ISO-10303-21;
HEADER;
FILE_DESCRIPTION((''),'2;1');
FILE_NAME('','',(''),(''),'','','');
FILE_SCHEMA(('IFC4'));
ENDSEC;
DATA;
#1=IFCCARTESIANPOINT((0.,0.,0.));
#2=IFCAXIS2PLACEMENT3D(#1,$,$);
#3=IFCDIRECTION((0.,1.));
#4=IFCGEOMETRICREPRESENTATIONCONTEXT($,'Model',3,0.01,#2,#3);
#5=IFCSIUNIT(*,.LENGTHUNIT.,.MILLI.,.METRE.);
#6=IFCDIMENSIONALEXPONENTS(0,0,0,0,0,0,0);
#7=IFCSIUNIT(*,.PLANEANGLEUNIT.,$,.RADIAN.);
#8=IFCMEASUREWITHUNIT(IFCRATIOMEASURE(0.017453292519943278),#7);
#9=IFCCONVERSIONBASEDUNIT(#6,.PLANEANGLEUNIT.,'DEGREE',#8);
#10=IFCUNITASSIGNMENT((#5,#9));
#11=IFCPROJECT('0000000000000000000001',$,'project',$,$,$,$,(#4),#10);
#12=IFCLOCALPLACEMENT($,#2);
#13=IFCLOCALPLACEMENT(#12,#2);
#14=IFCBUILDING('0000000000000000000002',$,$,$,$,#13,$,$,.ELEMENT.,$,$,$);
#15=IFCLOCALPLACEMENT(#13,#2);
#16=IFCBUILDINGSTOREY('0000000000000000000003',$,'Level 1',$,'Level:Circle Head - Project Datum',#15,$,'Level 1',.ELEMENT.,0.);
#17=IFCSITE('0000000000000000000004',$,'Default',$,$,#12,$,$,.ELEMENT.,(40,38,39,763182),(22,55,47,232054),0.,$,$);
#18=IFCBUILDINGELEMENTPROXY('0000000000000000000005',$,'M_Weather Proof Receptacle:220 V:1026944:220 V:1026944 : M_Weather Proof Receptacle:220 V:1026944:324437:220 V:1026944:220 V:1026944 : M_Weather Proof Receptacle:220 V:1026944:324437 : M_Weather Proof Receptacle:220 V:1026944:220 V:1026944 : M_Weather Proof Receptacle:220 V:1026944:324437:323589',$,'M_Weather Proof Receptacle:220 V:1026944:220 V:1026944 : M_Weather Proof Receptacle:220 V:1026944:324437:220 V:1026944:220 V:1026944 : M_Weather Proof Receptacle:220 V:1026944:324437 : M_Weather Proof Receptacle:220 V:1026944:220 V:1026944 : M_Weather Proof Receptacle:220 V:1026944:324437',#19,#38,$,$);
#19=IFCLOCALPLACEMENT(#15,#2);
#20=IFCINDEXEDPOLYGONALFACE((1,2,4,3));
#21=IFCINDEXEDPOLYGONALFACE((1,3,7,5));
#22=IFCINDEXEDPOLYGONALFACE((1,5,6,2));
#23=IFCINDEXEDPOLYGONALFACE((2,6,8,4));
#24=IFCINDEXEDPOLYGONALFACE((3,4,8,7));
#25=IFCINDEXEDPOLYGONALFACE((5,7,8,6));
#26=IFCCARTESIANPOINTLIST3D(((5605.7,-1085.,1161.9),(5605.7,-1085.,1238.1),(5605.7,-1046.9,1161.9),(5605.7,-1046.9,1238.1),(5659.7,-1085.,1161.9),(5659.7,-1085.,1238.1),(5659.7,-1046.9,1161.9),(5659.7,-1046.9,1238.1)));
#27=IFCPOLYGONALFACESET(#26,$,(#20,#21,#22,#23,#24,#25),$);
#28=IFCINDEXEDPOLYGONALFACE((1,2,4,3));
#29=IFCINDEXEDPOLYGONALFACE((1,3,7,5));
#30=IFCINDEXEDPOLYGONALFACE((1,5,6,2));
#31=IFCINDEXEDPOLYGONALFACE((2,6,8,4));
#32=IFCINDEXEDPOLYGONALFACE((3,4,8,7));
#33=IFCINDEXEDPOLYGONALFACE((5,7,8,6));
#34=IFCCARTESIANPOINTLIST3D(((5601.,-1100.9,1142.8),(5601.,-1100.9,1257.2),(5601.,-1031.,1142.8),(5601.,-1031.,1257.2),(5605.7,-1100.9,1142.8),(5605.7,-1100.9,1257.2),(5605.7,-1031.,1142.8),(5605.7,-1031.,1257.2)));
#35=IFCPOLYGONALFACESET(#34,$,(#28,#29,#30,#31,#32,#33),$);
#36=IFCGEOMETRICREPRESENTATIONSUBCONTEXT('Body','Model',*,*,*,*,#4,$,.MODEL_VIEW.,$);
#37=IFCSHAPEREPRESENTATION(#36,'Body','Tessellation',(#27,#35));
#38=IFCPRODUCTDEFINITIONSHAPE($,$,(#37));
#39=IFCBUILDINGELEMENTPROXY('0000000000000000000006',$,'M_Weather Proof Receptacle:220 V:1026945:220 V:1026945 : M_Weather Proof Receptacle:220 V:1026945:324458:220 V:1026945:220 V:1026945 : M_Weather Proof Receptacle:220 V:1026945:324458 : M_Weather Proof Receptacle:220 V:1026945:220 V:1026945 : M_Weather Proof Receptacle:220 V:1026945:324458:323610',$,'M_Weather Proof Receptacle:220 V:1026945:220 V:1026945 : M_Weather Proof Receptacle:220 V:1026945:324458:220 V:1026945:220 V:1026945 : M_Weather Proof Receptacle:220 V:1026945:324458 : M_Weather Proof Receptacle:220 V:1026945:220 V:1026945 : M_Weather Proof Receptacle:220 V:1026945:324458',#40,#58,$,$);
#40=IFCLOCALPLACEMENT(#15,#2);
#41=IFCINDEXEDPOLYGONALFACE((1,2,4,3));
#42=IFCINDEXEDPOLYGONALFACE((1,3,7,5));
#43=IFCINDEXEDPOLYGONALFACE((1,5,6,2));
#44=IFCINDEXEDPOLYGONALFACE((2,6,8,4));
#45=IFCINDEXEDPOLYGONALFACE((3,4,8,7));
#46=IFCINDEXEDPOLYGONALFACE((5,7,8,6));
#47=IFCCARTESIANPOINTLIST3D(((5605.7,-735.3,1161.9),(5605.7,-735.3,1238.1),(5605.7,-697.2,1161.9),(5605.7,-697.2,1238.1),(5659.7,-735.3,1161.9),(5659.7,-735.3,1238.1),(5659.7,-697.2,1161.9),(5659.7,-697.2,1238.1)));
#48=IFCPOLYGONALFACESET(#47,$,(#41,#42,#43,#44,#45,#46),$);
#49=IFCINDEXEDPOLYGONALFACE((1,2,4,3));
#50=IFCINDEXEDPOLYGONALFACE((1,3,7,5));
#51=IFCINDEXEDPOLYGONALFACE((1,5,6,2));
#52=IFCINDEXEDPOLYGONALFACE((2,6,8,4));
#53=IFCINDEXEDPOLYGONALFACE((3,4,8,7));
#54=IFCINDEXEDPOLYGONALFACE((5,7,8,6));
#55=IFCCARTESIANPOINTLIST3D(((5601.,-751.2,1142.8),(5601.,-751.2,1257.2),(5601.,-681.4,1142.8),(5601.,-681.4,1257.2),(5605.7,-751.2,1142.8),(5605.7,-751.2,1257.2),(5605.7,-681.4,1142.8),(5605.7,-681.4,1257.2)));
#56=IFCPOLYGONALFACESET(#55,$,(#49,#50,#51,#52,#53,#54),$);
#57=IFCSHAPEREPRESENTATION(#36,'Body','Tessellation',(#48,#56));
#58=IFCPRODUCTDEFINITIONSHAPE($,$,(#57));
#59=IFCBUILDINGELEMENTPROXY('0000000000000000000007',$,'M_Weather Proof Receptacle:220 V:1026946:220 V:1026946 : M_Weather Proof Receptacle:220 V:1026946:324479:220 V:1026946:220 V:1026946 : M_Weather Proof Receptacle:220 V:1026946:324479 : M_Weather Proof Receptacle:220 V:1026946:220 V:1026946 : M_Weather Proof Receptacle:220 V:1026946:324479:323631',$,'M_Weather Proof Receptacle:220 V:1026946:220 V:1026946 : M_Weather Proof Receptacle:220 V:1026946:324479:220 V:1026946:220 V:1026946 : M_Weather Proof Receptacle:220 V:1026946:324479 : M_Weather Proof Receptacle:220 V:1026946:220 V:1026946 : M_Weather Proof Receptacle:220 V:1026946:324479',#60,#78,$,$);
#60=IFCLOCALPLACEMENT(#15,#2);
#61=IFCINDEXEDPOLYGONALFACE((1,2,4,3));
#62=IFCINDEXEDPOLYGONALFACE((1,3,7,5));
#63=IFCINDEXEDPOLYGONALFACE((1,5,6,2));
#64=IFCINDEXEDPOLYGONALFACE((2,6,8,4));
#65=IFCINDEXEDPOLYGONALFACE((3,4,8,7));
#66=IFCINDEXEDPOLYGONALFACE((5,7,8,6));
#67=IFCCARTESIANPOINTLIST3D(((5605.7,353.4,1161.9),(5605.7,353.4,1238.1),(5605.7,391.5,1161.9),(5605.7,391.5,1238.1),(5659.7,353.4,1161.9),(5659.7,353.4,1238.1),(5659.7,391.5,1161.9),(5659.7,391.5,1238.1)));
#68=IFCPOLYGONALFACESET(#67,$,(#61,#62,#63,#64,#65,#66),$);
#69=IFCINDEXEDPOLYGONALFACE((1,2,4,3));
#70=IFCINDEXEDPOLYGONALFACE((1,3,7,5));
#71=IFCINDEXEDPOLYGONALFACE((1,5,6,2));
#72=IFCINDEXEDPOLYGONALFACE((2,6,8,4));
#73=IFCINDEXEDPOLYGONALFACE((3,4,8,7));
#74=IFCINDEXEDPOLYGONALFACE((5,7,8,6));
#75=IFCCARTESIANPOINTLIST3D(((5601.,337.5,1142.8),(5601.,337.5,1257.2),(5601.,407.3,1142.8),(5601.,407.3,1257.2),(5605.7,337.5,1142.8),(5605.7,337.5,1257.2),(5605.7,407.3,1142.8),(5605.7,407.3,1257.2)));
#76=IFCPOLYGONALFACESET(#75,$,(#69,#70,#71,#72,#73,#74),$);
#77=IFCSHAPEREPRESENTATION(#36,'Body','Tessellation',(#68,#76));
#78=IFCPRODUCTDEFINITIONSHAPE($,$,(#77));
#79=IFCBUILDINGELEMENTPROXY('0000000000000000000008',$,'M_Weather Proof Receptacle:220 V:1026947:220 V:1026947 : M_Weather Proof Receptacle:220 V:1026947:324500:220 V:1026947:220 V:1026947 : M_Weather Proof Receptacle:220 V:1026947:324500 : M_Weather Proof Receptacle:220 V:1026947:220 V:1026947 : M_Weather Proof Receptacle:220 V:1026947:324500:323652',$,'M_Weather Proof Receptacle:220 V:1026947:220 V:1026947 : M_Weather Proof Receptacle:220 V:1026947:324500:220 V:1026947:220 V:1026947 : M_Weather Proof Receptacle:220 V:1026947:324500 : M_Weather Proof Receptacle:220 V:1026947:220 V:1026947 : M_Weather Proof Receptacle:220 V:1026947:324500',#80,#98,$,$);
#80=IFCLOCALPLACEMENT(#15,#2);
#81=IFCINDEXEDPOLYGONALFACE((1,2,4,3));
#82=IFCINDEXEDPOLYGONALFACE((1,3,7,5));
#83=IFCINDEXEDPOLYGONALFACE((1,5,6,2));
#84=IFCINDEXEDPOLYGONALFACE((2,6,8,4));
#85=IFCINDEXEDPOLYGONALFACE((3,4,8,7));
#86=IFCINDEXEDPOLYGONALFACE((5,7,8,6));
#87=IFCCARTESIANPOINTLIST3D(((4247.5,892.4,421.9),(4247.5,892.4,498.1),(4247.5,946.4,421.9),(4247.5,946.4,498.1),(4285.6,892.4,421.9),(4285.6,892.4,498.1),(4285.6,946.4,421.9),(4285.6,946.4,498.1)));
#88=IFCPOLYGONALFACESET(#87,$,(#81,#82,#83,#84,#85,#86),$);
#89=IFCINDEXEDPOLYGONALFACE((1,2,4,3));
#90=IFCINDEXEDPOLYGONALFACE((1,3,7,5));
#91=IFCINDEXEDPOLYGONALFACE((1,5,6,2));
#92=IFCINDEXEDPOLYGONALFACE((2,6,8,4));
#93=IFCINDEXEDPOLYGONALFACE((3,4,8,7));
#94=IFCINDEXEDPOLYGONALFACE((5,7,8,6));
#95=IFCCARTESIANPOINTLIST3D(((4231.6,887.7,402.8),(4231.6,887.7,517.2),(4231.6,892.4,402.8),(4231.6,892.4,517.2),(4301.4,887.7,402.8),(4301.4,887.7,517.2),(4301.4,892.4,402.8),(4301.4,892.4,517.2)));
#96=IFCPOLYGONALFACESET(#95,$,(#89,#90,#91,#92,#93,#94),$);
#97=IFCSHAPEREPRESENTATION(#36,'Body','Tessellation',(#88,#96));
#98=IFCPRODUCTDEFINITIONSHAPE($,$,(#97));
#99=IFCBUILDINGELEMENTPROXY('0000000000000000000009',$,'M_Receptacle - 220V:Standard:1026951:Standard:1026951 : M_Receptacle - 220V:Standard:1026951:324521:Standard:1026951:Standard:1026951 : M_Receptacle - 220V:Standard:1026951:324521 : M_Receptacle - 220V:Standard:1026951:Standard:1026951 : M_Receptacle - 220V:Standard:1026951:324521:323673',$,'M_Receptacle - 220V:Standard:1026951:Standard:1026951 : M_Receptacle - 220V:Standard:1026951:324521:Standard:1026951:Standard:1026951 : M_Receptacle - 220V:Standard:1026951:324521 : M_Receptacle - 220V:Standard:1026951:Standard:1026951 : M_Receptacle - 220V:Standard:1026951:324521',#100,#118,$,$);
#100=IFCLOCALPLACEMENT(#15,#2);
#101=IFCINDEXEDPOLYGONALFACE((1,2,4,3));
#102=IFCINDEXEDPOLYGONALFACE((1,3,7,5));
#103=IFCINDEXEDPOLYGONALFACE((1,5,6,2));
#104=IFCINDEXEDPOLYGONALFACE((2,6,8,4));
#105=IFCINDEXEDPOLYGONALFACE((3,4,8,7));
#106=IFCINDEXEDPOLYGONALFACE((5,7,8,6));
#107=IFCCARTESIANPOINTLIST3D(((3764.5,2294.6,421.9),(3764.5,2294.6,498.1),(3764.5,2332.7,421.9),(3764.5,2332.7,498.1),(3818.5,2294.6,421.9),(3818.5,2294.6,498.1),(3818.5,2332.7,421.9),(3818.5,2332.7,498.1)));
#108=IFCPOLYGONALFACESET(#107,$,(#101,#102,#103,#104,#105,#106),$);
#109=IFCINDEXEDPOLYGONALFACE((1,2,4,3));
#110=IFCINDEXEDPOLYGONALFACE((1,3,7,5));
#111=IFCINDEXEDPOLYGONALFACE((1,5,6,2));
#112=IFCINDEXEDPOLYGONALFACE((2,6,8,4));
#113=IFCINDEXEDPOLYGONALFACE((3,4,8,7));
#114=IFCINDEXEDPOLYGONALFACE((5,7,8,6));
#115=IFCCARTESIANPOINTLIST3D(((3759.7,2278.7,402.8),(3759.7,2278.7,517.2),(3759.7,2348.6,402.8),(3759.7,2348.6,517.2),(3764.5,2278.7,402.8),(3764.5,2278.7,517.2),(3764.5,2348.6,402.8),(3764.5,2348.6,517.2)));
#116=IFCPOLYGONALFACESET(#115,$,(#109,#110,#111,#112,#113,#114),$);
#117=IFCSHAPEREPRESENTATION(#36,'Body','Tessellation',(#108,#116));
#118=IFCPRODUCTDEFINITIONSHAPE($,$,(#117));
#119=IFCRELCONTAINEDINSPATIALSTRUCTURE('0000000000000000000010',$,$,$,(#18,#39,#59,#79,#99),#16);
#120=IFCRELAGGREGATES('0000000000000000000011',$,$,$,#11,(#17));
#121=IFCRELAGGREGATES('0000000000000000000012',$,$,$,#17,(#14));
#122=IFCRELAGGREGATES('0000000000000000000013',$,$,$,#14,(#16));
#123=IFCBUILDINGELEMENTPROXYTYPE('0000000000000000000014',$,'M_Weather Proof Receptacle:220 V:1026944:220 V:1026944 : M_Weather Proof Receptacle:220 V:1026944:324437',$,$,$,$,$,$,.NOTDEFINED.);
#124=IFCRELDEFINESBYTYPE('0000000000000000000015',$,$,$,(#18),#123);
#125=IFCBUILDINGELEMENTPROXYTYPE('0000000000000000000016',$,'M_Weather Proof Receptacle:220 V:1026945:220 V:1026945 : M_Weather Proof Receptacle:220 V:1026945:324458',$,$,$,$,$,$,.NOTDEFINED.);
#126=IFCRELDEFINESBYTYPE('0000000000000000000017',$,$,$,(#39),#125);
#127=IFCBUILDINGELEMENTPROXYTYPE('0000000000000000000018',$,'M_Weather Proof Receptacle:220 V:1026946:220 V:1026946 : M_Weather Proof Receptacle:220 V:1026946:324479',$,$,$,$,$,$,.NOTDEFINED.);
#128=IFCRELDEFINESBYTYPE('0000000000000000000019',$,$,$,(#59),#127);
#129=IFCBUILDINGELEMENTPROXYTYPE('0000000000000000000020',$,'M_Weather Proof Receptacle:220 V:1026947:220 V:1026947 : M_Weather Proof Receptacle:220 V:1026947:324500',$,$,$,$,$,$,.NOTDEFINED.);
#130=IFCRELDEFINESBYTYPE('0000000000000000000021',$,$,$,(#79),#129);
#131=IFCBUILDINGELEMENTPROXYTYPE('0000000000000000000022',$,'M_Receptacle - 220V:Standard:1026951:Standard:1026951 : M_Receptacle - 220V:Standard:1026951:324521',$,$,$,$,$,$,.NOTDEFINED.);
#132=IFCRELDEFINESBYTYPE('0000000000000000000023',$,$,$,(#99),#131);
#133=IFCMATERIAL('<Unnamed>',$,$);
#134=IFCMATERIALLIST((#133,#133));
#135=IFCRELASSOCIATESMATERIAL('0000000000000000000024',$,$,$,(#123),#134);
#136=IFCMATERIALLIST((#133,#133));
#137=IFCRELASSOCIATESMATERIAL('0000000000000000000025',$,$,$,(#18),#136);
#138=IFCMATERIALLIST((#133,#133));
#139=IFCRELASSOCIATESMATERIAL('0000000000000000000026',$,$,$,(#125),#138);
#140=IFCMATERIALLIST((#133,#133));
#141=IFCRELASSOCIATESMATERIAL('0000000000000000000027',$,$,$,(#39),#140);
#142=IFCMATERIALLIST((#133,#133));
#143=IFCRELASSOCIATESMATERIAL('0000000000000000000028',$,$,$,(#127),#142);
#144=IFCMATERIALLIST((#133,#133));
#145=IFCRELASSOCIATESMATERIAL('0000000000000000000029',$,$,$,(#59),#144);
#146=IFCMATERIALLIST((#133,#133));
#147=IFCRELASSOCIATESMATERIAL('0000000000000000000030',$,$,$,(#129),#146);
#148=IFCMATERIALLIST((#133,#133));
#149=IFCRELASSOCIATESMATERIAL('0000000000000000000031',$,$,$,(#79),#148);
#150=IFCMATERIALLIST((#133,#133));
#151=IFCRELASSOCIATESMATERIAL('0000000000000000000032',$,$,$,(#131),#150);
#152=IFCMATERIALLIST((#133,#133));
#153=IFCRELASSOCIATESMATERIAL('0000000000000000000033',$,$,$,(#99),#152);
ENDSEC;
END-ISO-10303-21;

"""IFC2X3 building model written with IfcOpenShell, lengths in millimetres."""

from ifc_helpers import new_model, entity, si_unit, converted_unit, direction, frame, frame_2d, origin, origin_2d_with_axis, place, context, subcontext, project, spatial, rectangle, extrude, source, transform, mapped, material, material_list, type_object, type_shapes, element, save


model = new_model("IFC2X3")

# Units and contexts
model_context = context("Model", 3, precision=0.01, world=origin(), true_north=direction((0.0, 1.0)))
body_context = subcontext(model_context, "Body", "Model", "MODEL_VIEW")
ifc_project = project(units=[si_unit("LENGTHUNIT", "METRE", prefix="MILLI"), converted_unit("PLANEANGLEUNIT", "DEGREE", entity("IfcRatioMeasure", 0.017453292519943278), si_unit("PLANEANGLEUNIT", "RADIAN"), dimensions=[0, 0, 0, 0, 0, 0, 0])], contexts=[model_context])

# Site, building, storey
site_placement = place(None, origin())
site = spatial("IfcSite", under=ifc_project, at=site_placement, Name="Default", CompositionType="ELEMENT", RefLatitude=(40, 38, 39, 763182), RefLongitude=(22, 55, 47, 232054), RefElevation=0.0)
building_placement = place(site_placement, origin())
building = spatial("IfcBuilding", under=site, at=building_placement, CompositionType="ELEMENT")
storey_placement = place(building_placement, origin())
storey = spatial("IfcBuildingStorey", under=building, at=storey_placement, Name="Level 1", ObjectType="Level:Circle Head - Project Datum", LongName="Level 1", CompositionType="ELEMENT", Elevation=0.0)

# Shared definitions
ifc_material_1 = material(Name="<Unnamed>")

# Building element proxies
ifc_material_list_1 = material_list([ifc_material_1, ifc_material_1])
ifc_material_list_2 = material_list([ifc_material_1, ifc_material_1])
building_element_proxy_type_1 = type_object("IfcBuildingElementProxyType", Name="M_Weather Proof Receptacle:220 V:1026944:220 V:1026944 : M_Weather Proof Receptacle:220 V:1026944:324437", PredefinedType="NOTDEFINED", material=ifc_material_list_2)
shared_shape_1 = source(origin(), body_context, "Body", "SweptSolid", [
    extrude(rectangle(XDim=38.1, YDim=54.0, at=origin_2d_with_axis()), frame((5632.7, -1065.9, 1161.9), z_axis=(0.0, 0.0, 1.0), x_axis=(0.0, 1.0, 0.0)), (0.0, 0.0, 1.0), 76.2),
    extrude(rectangle(XDim=69.8, YDim=4.8, at=frame_2d((0.0, 0.0), x_axis=(1.0, 0.0))), frame((5603.3, -1065.9, 1142.8), z_axis=(0.0, 0.0, 1.0), x_axis=(0.0, 1.0, 0.0)), (0.0, 0.0, 1.0), 114.3),
])
type_shapes(building_element_proxy_type_1, [shared_shape_1])
proxy_1_placement = place(storey_placement, origin())
element("IfcBuildingElementProxy", 1, at=proxy_1_placement, inside=storey, type_object=building_element_proxy_type_1, material=ifc_material_list_1, Name="M_Weather Proof Receptacle:220 V:1026944:220 V:1026944 : M_Weather Proof Receptacle:220 V:1026944:324437:220 V:1026944:220 V:1026944 : M_Weather Proof Receptacle:220 V:1026944:324437 : M_Weather Proof Receptacle:220 V:1026944:220 V:1026944 : M_Weather Proof Receptacle:220 V:1026944:324437:323589", ObjectType="M_Weather Proof Receptacle:220 V:1026944:220 V:1026944 : M_Weather Proof Receptacle:220 V:1026944:324437:220 V:1026944:220 V:1026944 : M_Weather Proof Receptacle:220 V:1026944:324437 : M_Weather Proof Receptacle:220 V:1026944:220 V:1026944 : M_Weather Proof Receptacle:220 V:1026944:324437", context=body_context, shape_type="MappedRepresentation", body=[
    mapped(shared_shape_1, transform((0.0, 0.0, 0.0), scale=1.0)),
])
ifc_material_list_3 = material_list([ifc_material_1, ifc_material_1])
ifc_material_list_4 = material_list([ifc_material_1, ifc_material_1])
building_element_proxy_type_2 = type_object("IfcBuildingElementProxyType", Name="M_Weather Proof Receptacle:220 V:1026945:220 V:1026945 : M_Weather Proof Receptacle:220 V:1026945:324458", PredefinedType="NOTDEFINED", material=ifc_material_list_4)
shared_shape_2 = source(origin(), body_context, "Body", "SweptSolid", [
    extrude(rectangle(XDim=38.1, YDim=54.0, at=origin_2d_with_axis()), frame((5632.7, -716.3, 1161.9), z_axis=(0.0, 0.0, 1.0), x_axis=(0.0, 1.0, 0.0)), (0.0, 0.0, 1.0), 76.2),
    extrude(rectangle(XDim=69.8, YDim=4.8, at=frame_2d((0.0, 0.0), x_axis=(1.0, 0.0))), frame((5603.3, -716.3, 1142.8), z_axis=(0.0, 0.0, 1.0), x_axis=(0.0, 1.0, 0.0)), (0.0, 0.0, 1.0), 114.3),
])
type_shapes(building_element_proxy_type_2, [shared_shape_2])
proxy_2_placement = place(storey_placement, origin())
element("IfcBuildingElementProxy", 2, at=proxy_2_placement, inside=storey, type_object=building_element_proxy_type_2, material=ifc_material_list_3, Name="M_Weather Proof Receptacle:220 V:1026945:220 V:1026945 : M_Weather Proof Receptacle:220 V:1026945:324458:220 V:1026945:220 V:1026945 : M_Weather Proof Receptacle:220 V:1026945:324458 : M_Weather Proof Receptacle:220 V:1026945:220 V:1026945 : M_Weather Proof Receptacle:220 V:1026945:324458:323610", ObjectType="M_Weather Proof Receptacle:220 V:1026945:220 V:1026945 : M_Weather Proof Receptacle:220 V:1026945:324458:220 V:1026945:220 V:1026945 : M_Weather Proof Receptacle:220 V:1026945:324458 : M_Weather Proof Receptacle:220 V:1026945:220 V:1026945 : M_Weather Proof Receptacle:220 V:1026945:324458", context=body_context, shape_type="MappedRepresentation", body=[
    mapped(shared_shape_2, transform((0.0, 0.0, 0.0), scale=1.0)),
])
ifc_material_list_5 = material_list([ifc_material_1, ifc_material_1])
ifc_material_list_6 = material_list([ifc_material_1, ifc_material_1])
building_element_proxy_type_3 = type_object("IfcBuildingElementProxyType", Name="M_Weather Proof Receptacle:220 V:1026946:220 V:1026946 : M_Weather Proof Receptacle:220 V:1026946:324479", PredefinedType="NOTDEFINED", material=ifc_material_list_6)
shared_shape_3 = source(origin(), body_context, "Body", "SweptSolid", [
    extrude(rectangle(XDim=38.1, YDim=54.0, at=frame_2d((0.0, 0.0), x_axis=(1.0, 0.0))), frame((5632.7, 372.4, 1161.9), z_axis=(0.0, 0.0, 1.0), x_axis=(0.0, 1.0, 0.0)), (0.0, 0.0, 1.0), 76.2),
    extrude(rectangle(XDim=69.8, YDim=4.8, at=frame_2d((0.0, 0.0), x_axis=(1.0, 0.0))), frame((5603.3, 372.4, 1142.8), z_axis=(0.0, 0.0, 1.0), x_axis=(0.0, 1.0, 0.0)), (0.0, 0.0, 1.0), 114.3),
])
type_shapes(building_element_proxy_type_3, [shared_shape_3])
proxy_3_placement = place(storey_placement, origin())
element("IfcBuildingElementProxy", 3, at=proxy_3_placement, inside=storey, type_object=building_element_proxy_type_3, material=ifc_material_list_5, Name="M_Weather Proof Receptacle:220 V:1026946:220 V:1026946 : M_Weather Proof Receptacle:220 V:1026946:324479:220 V:1026946:220 V:1026946 : M_Weather Proof Receptacle:220 V:1026946:324479 : M_Weather Proof Receptacle:220 V:1026946:220 V:1026946 : M_Weather Proof Receptacle:220 V:1026946:324479:323631", ObjectType="M_Weather Proof Receptacle:220 V:1026946:220 V:1026946 : M_Weather Proof Receptacle:220 V:1026946:324479:220 V:1026946:220 V:1026946 : M_Weather Proof Receptacle:220 V:1026946:324479 : M_Weather Proof Receptacle:220 V:1026946:220 V:1026946 : M_Weather Proof Receptacle:220 V:1026946:324479", context=body_context, shape_type="MappedRepresentation", body=[
    mapped(shared_shape_3, transform((0.0, 0.0, 0.0), scale=1.0)),
])
ifc_material_list_7 = material_list([ifc_material_1, ifc_material_1])
ifc_material_list_8 = material_list([ifc_material_1, ifc_material_1])
building_element_proxy_type_4 = type_object("IfcBuildingElementProxyType", Name="M_Weather Proof Receptacle:220 V:1026947:220 V:1026947 : M_Weather Proof Receptacle:220 V:1026947:324500", PredefinedType="NOTDEFINED", material=ifc_material_list_8)
shared_shape_4 = source(origin(), body_context, "Body", "SweptSolid", [
    extrude(rectangle(XDim=38.1, YDim=54.0, at=frame_2d((0.0, 0.0), x_axis=(1.0, 0.0))), frame((4266.5, 919.4, 421.9), z_axis=(0.0, 0.0, 1.0), x_axis=(-1.0, 0.0, 0.0)), (0.0, 0.0, 1.0), 76.2),
    extrude(rectangle(XDim=69.8, YDim=4.8, at=frame_2d((0.0, 0.0), x_axis=(1.0, 0.0))), frame((4266.5, 890.0, 402.8), z_axis=(0.0, 0.0, 1.0), x_axis=(-1.0, 0.0, 0.0)), (0.0, 0.0, 1.0), 114.3),
])
type_shapes(building_element_proxy_type_4, [shared_shape_4])
proxy_4_placement = place(storey_placement, origin())
element("IfcBuildingElementProxy", 4, at=proxy_4_placement, inside=storey, type_object=building_element_proxy_type_4, material=ifc_material_list_7, Name="M_Weather Proof Receptacle:220 V:1026947:220 V:1026947 : M_Weather Proof Receptacle:220 V:1026947:324500:220 V:1026947:220 V:1026947 : M_Weather Proof Receptacle:220 V:1026947:324500 : M_Weather Proof Receptacle:220 V:1026947:220 V:1026947 : M_Weather Proof Receptacle:220 V:1026947:324500:323652", ObjectType="M_Weather Proof Receptacle:220 V:1026947:220 V:1026947 : M_Weather Proof Receptacle:220 V:1026947:324500:220 V:1026947:220 V:1026947 : M_Weather Proof Receptacle:220 V:1026947:324500 : M_Weather Proof Receptacle:220 V:1026947:220 V:1026947 : M_Weather Proof Receptacle:220 V:1026947:324500", context=body_context, shape_type="MappedRepresentation", body=[
    mapped(shared_shape_4, transform((0.0, 0.0, 0.0), scale=1.0)),
])
ifc_material_list_9 = material_list([ifc_material_1, ifc_material_1])
ifc_material_list_10 = material_list([ifc_material_1, ifc_material_1])
building_element_proxy_type_5 = type_object("IfcBuildingElementProxyType", Name="M_Receptacle - 220V:Standard:1026951:Standard:1026951 : M_Receptacle - 220V:Standard:1026951:324521", PredefinedType="NOTDEFINED", material=ifc_material_list_10)
shared_shape_5 = source(origin(), body_context, "Body", "SweptSolid", [
    extrude(rectangle(XDim=38.1, YDim=54.0, at=origin_2d_with_axis()), frame((3791.5, 2313.7, 421.9), z_axis=(0.0, 0.0, 1.0), x_axis=(0.0, 1.0, 0.0)), (0.0, 0.0, 1.0), 76.2),
    extrude(rectangle(XDim=69.8, YDim=4.8, at=origin_2d_with_axis()), frame((3762.1, 2313.7, 402.8), z_axis=(0.0, 0.0, 1.0), x_axis=(0.0, 1.0, 0.0)), (0.0, 0.0, 1.0), 114.3),
])
type_shapes(building_element_proxy_type_5, [shared_shape_5])
proxy_5_placement = place(storey_placement, origin())
element("IfcBuildingElementProxy", 5, at=proxy_5_placement, inside=storey, type_object=building_element_proxy_type_5, material=ifc_material_list_9, Name="M_Receptacle - 220V:Standard:1026951:Standard:1026951 : M_Receptacle - 220V:Standard:1026951:324521:Standard:1026951:Standard:1026951 : M_Receptacle - 220V:Standard:1026951:324521 : M_Receptacle - 220V:Standard:1026951:Standard:1026951 : M_Receptacle - 220V:Standard:1026951:324521:323673", ObjectType="M_Receptacle - 220V:Standard:1026951:Standard:1026951 : M_Receptacle - 220V:Standard:1026951:324521:Standard:1026951:Standard:1026951 : M_Receptacle - 220V:Standard:1026951:324521 : M_Receptacle - 220V:Standard:1026951:Standard:1026951 : M_Receptacle - 220V:Standard:1026951:324521", context=body_context, shape_type="MappedRepresentation", body=[
    mapped(shared_shape_5, transform((0.0, 0.0, 0.0), scale=1.0)),
])

save(model, "model.ifc")
